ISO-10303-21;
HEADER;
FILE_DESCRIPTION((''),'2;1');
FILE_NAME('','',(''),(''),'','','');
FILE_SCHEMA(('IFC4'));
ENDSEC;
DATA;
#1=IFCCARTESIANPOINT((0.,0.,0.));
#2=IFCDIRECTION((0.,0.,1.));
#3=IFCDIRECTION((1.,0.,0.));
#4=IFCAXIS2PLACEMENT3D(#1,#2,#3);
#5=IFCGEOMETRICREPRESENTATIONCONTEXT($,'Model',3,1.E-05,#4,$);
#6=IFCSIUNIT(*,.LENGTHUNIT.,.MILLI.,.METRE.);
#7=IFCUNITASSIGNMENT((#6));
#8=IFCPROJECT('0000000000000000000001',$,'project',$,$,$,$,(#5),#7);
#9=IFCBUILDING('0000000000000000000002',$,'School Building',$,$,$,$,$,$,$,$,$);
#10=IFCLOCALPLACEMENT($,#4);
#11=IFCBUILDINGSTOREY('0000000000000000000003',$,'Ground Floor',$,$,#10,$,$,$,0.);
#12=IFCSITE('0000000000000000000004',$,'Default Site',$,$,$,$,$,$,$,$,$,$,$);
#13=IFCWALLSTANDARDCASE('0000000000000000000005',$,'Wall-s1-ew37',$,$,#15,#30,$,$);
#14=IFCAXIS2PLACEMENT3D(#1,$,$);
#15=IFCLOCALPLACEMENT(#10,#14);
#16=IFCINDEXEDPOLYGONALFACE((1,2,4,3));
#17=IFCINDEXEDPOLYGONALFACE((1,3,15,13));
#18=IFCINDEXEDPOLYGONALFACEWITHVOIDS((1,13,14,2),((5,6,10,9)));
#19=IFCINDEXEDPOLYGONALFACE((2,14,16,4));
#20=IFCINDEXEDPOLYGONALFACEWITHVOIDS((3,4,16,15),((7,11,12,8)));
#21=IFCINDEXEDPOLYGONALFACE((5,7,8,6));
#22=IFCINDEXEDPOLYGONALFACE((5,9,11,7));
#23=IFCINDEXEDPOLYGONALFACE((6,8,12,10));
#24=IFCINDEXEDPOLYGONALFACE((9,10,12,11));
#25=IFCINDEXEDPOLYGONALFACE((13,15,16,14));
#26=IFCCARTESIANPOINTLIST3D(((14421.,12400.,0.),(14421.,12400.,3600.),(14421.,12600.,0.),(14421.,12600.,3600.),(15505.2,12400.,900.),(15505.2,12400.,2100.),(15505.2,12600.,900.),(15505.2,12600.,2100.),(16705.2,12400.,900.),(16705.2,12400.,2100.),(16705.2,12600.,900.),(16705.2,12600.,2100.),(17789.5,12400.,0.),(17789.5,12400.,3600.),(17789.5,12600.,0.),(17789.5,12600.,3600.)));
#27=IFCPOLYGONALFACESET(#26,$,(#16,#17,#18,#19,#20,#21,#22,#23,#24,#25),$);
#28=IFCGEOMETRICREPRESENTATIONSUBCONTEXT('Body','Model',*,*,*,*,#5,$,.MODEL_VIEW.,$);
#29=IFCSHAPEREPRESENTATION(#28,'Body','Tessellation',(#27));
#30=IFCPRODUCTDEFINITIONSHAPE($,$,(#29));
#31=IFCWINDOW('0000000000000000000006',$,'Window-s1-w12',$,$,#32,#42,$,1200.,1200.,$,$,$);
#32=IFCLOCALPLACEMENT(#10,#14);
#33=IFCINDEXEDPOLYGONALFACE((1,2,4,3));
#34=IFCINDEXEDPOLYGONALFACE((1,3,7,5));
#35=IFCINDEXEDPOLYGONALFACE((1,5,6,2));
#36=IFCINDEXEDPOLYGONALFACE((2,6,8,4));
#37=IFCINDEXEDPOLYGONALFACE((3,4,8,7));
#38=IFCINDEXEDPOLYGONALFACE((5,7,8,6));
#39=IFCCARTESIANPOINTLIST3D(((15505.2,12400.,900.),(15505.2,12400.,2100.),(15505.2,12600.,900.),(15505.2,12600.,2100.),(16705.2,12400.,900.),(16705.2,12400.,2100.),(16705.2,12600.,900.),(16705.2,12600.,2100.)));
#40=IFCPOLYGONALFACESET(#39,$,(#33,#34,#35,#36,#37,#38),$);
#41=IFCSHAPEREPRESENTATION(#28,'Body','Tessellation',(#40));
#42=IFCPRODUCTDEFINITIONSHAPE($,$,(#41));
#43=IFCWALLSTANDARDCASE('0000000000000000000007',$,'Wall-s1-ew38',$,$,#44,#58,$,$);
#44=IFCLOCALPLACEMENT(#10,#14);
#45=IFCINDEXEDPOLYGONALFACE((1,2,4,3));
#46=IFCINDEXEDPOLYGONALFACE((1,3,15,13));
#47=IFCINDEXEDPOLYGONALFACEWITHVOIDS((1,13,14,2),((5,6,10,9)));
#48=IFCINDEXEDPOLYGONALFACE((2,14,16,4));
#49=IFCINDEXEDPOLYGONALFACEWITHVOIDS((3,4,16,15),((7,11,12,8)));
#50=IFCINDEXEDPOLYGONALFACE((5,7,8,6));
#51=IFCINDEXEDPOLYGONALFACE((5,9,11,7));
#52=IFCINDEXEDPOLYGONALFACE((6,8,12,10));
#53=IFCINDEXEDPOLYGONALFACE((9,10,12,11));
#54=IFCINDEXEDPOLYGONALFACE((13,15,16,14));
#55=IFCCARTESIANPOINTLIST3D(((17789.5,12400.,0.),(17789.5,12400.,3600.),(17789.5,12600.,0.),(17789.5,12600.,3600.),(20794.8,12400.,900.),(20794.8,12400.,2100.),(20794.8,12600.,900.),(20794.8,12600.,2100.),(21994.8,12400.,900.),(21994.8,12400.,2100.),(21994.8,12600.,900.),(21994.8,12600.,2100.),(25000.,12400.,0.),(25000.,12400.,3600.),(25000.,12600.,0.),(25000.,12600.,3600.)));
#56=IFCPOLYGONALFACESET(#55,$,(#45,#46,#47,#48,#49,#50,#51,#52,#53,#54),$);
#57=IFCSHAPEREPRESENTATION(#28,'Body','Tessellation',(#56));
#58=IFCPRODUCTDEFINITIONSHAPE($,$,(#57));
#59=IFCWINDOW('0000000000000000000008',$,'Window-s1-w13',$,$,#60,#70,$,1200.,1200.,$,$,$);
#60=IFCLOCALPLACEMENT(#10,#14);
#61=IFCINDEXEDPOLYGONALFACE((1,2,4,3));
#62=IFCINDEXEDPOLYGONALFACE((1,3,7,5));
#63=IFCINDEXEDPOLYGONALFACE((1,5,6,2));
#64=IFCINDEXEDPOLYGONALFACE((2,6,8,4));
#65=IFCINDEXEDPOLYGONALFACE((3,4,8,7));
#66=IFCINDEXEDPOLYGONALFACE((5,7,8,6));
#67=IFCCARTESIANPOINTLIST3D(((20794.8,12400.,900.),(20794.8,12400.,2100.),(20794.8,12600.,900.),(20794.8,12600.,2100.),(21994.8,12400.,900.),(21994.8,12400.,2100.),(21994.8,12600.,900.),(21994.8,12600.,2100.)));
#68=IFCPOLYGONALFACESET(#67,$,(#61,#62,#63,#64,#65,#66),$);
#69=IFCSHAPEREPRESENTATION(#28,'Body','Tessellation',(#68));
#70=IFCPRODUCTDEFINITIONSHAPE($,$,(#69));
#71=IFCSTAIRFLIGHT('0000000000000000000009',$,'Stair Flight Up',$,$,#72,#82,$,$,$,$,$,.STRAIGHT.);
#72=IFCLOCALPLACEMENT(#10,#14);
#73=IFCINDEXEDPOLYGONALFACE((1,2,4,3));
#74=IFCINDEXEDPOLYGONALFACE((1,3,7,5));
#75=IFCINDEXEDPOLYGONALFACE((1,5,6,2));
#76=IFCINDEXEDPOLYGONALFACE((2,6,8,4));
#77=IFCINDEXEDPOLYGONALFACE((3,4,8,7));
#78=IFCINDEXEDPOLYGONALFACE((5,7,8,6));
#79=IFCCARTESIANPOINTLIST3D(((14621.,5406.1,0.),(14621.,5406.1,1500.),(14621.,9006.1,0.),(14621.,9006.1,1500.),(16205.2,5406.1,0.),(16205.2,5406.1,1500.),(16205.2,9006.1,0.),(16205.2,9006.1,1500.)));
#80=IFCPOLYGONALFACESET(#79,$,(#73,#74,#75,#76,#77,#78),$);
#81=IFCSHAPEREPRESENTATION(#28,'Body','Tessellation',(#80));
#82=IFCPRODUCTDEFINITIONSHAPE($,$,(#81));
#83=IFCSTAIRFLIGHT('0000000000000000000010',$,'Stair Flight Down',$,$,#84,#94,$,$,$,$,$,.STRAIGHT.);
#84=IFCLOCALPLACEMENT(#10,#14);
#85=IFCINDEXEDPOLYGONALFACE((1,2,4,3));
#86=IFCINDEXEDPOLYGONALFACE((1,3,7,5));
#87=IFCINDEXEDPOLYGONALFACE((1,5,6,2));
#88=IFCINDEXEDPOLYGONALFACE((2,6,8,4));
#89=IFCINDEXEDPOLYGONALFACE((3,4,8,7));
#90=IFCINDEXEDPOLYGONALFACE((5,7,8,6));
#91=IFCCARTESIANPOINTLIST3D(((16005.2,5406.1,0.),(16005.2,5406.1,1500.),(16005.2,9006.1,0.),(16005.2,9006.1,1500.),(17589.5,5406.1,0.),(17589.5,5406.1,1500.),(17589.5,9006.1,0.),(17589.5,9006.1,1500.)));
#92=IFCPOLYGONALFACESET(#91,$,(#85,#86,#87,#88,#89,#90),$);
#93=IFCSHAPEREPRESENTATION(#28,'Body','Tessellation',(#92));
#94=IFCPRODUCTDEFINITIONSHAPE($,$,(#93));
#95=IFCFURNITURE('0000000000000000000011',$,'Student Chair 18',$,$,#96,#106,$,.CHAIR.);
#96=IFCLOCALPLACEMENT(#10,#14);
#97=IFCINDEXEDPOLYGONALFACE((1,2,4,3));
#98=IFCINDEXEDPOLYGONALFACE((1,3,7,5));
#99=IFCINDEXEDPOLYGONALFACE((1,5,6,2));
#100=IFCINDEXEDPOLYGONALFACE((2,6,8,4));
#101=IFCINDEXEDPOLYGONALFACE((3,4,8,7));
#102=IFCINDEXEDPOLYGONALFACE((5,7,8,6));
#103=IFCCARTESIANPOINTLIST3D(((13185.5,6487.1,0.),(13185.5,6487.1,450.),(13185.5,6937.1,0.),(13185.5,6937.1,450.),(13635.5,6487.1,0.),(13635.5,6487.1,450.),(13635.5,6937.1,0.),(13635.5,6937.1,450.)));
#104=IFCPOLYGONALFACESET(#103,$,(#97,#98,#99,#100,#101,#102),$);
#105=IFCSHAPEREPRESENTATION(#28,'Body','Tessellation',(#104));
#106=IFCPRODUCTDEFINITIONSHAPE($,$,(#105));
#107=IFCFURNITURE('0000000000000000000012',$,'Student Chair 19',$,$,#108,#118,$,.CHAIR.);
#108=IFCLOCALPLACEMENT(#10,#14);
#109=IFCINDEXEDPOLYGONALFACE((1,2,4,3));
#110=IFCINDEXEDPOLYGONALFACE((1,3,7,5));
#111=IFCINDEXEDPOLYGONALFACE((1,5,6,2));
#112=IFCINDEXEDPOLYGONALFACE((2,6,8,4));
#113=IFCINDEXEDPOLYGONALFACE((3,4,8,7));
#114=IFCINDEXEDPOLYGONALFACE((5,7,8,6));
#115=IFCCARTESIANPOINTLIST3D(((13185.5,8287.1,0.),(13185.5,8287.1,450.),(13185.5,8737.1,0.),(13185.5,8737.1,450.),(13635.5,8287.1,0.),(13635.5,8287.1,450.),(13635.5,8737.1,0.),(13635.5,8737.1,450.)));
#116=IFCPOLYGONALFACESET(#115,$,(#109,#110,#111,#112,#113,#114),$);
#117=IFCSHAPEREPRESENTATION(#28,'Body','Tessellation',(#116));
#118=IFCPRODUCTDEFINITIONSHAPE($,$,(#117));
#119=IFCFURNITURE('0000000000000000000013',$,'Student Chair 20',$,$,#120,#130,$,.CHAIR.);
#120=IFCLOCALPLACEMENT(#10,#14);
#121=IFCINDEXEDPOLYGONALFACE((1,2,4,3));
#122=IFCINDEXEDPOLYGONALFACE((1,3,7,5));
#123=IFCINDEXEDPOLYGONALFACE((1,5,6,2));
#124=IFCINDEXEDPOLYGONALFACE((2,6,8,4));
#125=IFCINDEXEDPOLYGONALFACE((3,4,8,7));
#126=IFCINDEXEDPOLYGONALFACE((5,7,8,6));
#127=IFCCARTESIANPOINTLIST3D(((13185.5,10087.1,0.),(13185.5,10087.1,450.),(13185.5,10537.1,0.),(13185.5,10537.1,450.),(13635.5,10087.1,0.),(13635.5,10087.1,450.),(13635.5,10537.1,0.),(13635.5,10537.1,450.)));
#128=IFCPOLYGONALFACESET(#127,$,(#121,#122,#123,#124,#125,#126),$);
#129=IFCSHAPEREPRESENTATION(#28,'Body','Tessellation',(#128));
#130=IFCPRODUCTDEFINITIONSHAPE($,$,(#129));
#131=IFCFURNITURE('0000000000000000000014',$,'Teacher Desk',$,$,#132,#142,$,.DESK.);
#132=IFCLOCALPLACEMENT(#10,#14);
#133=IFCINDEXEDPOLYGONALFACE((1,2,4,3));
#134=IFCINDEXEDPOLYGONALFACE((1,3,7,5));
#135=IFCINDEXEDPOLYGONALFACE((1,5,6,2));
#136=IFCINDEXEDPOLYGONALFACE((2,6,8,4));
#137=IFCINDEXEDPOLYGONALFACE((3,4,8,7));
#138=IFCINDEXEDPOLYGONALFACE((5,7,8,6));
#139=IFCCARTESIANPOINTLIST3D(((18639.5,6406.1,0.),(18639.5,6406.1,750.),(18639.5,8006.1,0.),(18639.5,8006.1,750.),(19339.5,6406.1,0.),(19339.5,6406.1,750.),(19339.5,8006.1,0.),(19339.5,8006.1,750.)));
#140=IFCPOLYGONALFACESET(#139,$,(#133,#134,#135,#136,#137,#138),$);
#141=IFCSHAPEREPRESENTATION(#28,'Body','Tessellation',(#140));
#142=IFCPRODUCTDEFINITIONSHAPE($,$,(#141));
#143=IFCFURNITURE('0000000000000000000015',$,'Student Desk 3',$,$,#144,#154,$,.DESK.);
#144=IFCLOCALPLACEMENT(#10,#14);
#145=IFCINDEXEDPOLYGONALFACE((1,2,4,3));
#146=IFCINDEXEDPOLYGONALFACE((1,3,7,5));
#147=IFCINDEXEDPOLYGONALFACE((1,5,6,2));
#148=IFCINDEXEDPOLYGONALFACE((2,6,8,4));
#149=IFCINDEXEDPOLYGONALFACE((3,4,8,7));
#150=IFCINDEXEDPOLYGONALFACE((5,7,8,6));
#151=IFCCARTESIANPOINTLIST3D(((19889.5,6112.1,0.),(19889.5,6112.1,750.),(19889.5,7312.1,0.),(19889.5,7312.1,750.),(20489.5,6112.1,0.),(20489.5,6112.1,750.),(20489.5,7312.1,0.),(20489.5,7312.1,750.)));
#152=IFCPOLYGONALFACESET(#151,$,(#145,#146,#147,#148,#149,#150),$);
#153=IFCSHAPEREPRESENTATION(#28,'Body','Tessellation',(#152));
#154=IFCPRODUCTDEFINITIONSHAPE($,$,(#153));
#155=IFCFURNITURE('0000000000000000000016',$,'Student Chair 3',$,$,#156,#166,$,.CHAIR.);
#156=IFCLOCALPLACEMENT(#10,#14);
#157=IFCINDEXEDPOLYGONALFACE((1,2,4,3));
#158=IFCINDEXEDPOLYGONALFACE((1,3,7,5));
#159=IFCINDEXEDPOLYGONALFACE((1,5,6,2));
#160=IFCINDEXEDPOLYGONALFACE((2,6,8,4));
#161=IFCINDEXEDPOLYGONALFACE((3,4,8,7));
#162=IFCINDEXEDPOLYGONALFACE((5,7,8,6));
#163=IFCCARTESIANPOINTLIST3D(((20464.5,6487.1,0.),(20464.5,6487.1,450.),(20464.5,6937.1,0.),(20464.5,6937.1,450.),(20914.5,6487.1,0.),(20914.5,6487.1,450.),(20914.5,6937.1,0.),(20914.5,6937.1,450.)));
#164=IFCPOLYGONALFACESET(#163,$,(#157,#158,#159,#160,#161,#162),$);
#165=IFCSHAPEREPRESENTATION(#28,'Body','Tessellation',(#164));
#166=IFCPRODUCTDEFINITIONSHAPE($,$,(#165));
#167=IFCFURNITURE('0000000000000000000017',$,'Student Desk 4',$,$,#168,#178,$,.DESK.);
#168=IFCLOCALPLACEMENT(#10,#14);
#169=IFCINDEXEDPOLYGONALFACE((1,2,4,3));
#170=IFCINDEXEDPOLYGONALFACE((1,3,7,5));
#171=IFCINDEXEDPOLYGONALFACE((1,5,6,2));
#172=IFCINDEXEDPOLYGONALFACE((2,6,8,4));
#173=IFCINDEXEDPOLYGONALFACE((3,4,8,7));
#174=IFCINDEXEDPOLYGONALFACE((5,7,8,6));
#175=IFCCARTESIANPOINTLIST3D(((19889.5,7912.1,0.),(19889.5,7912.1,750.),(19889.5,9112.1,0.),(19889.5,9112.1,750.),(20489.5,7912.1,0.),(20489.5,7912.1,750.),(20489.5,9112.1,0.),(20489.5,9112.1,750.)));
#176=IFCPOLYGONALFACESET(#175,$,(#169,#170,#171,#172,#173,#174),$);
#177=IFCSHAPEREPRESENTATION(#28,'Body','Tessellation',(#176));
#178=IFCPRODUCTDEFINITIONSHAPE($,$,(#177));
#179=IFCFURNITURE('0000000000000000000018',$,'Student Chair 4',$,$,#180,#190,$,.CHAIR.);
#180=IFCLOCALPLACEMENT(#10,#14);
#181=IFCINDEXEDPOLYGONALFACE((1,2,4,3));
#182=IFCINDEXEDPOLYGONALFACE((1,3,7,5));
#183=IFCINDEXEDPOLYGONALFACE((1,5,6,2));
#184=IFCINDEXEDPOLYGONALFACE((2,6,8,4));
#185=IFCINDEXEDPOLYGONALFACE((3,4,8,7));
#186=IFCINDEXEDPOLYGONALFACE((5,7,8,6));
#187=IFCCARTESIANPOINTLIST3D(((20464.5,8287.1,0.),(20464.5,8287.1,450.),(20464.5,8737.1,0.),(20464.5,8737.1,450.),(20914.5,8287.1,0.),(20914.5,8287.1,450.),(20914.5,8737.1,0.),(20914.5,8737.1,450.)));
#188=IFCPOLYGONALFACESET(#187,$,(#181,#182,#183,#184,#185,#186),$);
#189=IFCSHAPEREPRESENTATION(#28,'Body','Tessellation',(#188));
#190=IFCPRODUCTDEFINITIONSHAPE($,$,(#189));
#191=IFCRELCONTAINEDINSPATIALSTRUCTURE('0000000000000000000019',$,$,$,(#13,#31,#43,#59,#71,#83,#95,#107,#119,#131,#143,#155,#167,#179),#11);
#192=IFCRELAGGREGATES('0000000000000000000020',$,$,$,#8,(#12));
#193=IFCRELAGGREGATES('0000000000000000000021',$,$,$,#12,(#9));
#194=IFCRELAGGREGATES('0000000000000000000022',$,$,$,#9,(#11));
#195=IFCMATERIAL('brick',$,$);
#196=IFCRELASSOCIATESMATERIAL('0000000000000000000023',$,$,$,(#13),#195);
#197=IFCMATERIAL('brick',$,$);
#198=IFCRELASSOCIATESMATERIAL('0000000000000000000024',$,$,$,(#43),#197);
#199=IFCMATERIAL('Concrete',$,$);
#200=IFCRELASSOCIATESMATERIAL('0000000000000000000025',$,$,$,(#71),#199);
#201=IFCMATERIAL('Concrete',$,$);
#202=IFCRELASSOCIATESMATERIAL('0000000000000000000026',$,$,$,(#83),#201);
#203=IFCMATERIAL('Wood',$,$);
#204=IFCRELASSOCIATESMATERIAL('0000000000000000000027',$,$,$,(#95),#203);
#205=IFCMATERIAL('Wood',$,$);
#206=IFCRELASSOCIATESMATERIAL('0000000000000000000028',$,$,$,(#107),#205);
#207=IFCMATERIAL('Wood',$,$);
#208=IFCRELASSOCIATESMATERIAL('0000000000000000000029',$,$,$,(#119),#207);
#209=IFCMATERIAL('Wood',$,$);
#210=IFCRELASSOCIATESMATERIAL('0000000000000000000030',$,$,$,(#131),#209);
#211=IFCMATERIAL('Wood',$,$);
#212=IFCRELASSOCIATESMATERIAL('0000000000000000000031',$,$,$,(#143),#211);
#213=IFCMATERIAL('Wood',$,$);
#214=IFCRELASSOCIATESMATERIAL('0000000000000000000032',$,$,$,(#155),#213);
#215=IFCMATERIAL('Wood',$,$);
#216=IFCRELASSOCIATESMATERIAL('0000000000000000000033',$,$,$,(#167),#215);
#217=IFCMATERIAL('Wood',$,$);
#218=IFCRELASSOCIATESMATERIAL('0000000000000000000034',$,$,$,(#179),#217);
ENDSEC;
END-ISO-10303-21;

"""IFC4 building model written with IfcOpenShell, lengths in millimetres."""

from ifc_helpers import new_model, si_unit, frame, frame_2d, origin_with_axes, origin_2d, place, context, subcontext, project, spatial, rectangle, extrude, material, element, fill, save


model = new_model("IFC4")

# Units and contexts
model_context = context("Model", 3, precision=1e-05, world=origin_with_axes())
body_context = subcontext(model_context, "Body", "Model", "MODEL_VIEW")
ifc_project = project(units=[si_unit("LENGTHUNIT", "METRE", prefix="MILLI")], contexts=[model_context])

# Site, building, storey
site = spatial("IfcSite", under=ifc_project, Name="Default Site")
building = spatial("IfcBuilding", under=site, Name="School Building")
storey_placement = place(None, origin_with_axes())
storey = spatial("IfcBuildingStorey", under=building, at=storey_placement, Name="Ground Floor", Elevation=0.0)

# Walls, openings, windows
ifc_material_1 = material(Name="brick")
wall_1_placement = place(storey_placement, frame((14421.0, 12500.0, 0.0), z_axis=(0.0, 0.0, 1.0), x_axis=(1.0, 0.0, 0.0)))
wall_1 = element("IfcWallStandardCase", 1, at=wall_1_placement, inside=storey, material=ifc_material_1, Name="Wall-s1-ew37", context=body_context, shape_type="SweptSolid", body=[
    extrude(rectangle(XDim=3368.6, YDim=200.0, at=frame_2d((1684.3, 0.0))), origin_with_axes(), (0.0, 0.0, 1.0), 3600.0),
])
opening_1_placement = place(wall_1_placement, frame((1084.3, 0.0, 900.0), z_axis=(0.0, 0.0, 1.0), x_axis=(1.0, 0.0, 0.0)))
opening_1 = element("IfcOpeningElement", 2, at=opening_1_placement, cuts=wall_1, context=body_context, shape_type="SweptSolid", body=[
    extrude(rectangle(XDim=1200.0, YDim=400.0, at=frame_2d((600.0, 0.0))), origin_with_axes(), (0.0, 0.0, 1.0), 1200.0),
])
window_1_placement = place(storey_placement, frame((15505.2, 12500.0, 900.0), z_axis=(0.0, 0.0, 1.0), x_axis=(1.0, 0.0, 0.0)))
window_1 = element("IfcWindow", 3, at=window_1_placement, inside=storey, Name="Window-s1-w12", OverallHeight=1200.0, OverallWidth=1200.0, context=body_context, shape_type="SweptSolid", body=[
    extrude(rectangle(XDim=1200.0, YDim=200.0, at=frame_2d((600.0, 0.0))), origin_with_axes(), (0.0, 0.0, 1.0), 1200.0),
])
fill(opening_1, window_1)
ifc_material_2 = material(Name="brick")
wall_2_placement = place(storey_placement, frame((17789.5, 12500.0, 0.0), z_axis=(0.0, 0.0, 1.0), x_axis=(1.0, 0.0, 0.0)))
wall_2 = element("IfcWallStandardCase", 4, at=wall_2_placement, inside=storey, material=ifc_material_2, Name="Wall-s1-ew38", context=body_context, shape_type="SweptSolid", body=[
    extrude(rectangle(XDim=7210.5, YDim=200.0, at=frame_2d((3605.2, 0.0))), origin_with_axes(), (0.0, 0.0, 1.0), 3600.0),
])
opening_2_placement = place(wall_2_placement, frame((3005.2, 0.0, 900.0), z_axis=(0.0, 0.0, 1.0), x_axis=(1.0, 0.0, 0.0)))
opening_2 = element("IfcOpeningElement", 5, at=opening_2_placement, cuts=wall_2, context=body_context, shape_type="SweptSolid", body=[
    extrude(rectangle(XDim=1200.0, YDim=400.0, at=frame_2d((600.0, 0.0))), origin_with_axes(), (0.0, 0.0, 1.0), 1200.0),
])
window_2_placement = place(storey_placement, frame((20794.8, 12500.0, 900.0), z_axis=(0.0, 0.0, 1.0), x_axis=(1.0, 0.0, 0.0)))
window_2 = element("IfcWindow", 6, at=window_2_placement, inside=storey, Name="Window-s1-w13", OverallHeight=1200.0, OverallWidth=1200.0, context=body_context, shape_type="SweptSolid", body=[
    extrude(rectangle(XDim=1200.0, YDim=200.0, at=frame_2d((600.0, 0.0))), origin_with_axes(), (0.0, 0.0, 1.0), 1200.0),
])
fill(opening_2, window_2)

# Stair flights
ifc_material_3 = material(Name="Concrete")
stair_flight_1_placement = place(storey_placement, frame((15413.1, 7206.1, 0.0), z_axis=(0.0, 0.0, 1.0), x_axis=(1.0, 0.0, 0.0)))
element("IfcStairFlight", 7, at=stair_flight_1_placement, inside=storey, material=ifc_material_3, Name="Stair Flight Up", PredefinedType="STRAIGHT", context=body_context, shape_type="SweptSolid", body=[
    extrude(rectangle(XDim=1584.3, YDim=3600.0, at=origin_2d()), origin_with_axes(), (0.0, 0.0, 1.0), 1500.0),
])
ifc_material_4 = material(Name="Concrete")
stair_flight_2_placement = place(storey_placement, frame((16797.4, 7206.1, 0.0), z_axis=(0.0, 0.0, 1.0), x_axis=(1.0, 0.0, 0.0)))
element("IfcStairFlight", 8, at=stair_flight_2_placement, inside=storey, material=ifc_material_4, Name="Stair Flight Down", PredefinedType="STRAIGHT", context=body_context, shape_type="SweptSolid", body=[
    extrude(rectangle(XDim=1584.3, YDim=3600.0, at=origin_2d()), origin_with_axes(), (0.0, 0.0, 1.0), 1500.0),
])

# Furniture
ifc_material_5 = material(Name="Wood")
furniture_1_placement = place(storey_placement, frame((13410.5, 6712.1, 0.0), z_axis=(0.0, 0.0, 1.0), x_axis=(1.0, 0.0, 0.0)))
element("IfcFurniture", 9, at=furniture_1_placement, inside=storey, material=ifc_material_5, Name="Student Chair 18", PredefinedType="CHAIR", context=body_context, shape_type="SweptSolid", body=[
    extrude(rectangle(XDim=450.0, YDim=450.0, at=origin_2d()), origin_with_axes(), (0.0, 0.0, 1.0), 450.0),
])
ifc_material_6 = material(Name="Wood")
furniture_2_placement = place(storey_placement, frame((13410.5, 8512.1, 0.0), z_axis=(0.0, 0.0, 1.0), x_axis=(1.0, 0.0, 0.0)))
element("IfcFurniture", 10, at=furniture_2_placement, inside=storey, material=ifc_material_6, Name="Student Chair 19", PredefinedType="CHAIR", context=body_context, shape_type="SweptSolid", body=[
    extrude(rectangle(XDim=450.0, YDim=450.0, at=origin_2d()), origin_with_axes(), (0.0, 0.0, 1.0), 450.0),
])
ifc_material_7 = material(Name="Wood")
furniture_3_placement = place(storey_placement, frame((13410.5, 10312.1, 0.0), z_axis=(0.0, 0.0, 1.0), x_axis=(1.0, 0.0, 0.0)))
element("IfcFurniture", 11, at=furniture_3_placement, inside=storey, material=ifc_material_7, Name="Student Chair 20", PredefinedType="CHAIR", context=body_context, shape_type="SweptSolid", body=[
    extrude(rectangle(XDim=450.0, YDim=450.0, at=origin_2d()), origin_with_axes(), (0.0, 0.0, 1.0), 450.0),
])
ifc_material_8 = material(Name="Wood")
furniture_4_placement = place(storey_placement, frame((18989.5, 7206.1, 0.0), z_axis=(0.0, 0.0, 1.0), x_axis=(0.0, 1.0, 0.0)))
element("IfcFurniture", 12, at=furniture_4_placement, inside=storey, material=ifc_material_8, Name="Teacher Desk", PredefinedType="DESK", context=body_context, shape_type="SweptSolid", body=[
    extrude(rectangle(XDim=1600.0, YDim=700.0, at=origin_2d()), origin_with_axes(), (0.0, 0.0, 1.0), 750.0),
])
ifc_material_9 = material(Name="Wood")
furniture_5_placement = place(storey_placement, frame((20189.5, 6712.1, 0.0), z_axis=(0.0, 0.0, 1.0), x_axis=(0.0, 1.0, 0.0)))
element("IfcFurniture", 13, at=furniture_5_placement, inside=storey, material=ifc_material_9, Name="Student Desk 3", PredefinedType="DESK", context=body_context, shape_type="SweptSolid", body=[
    extrude(rectangle(XDim=1200.0, YDim=600.0, at=origin_2d()), origin_with_axes(), (0.0, 0.0, 1.0), 750.0),
])
ifc_material_10 = material(Name="Wood")
furniture_6_placement = place(storey_placement, frame((20689.5, 6712.1, 0.0), z_axis=(0.0, 0.0, 1.0), x_axis=(1.0, 0.0, 0.0)))
element("IfcFurniture", 14, at=furniture_6_placement, inside=storey, material=ifc_material_10, Name="Student Chair 3", PredefinedType="CHAIR", context=body_context, shape_type="SweptSolid", body=[
    extrude(rectangle(XDim=450.0, YDim=450.0, at=origin_2d()), origin_with_axes(), (0.0, 0.0, 1.0), 450.0),
])
ifc_material_11 = material(Name="Wood")
furniture_7_placement = place(storey_placement, frame((20189.5, 8512.1, 0.0), z_axis=(0.0, 0.0, 1.0), x_axis=(0.0, 1.0, 0.0)))
element("IfcFurniture", 15, at=furniture_7_placement, inside=storey, material=ifc_material_11, Name="Student Desk 4", PredefinedType="DESK", context=body_context, shape_type="SweptSolid", body=[
    extrude(rectangle(XDim=1200.0, YDim=600.0, at=origin_2d()), origin_with_axes(), (0.0, 0.0, 1.0), 750.0),
])
ifc_material_12 = material(Name="Wood")
furniture_8_placement = place(storey_placement, frame((20689.5, 8512.1, 0.0), z_axis=(0.0, 0.0, 1.0), x_axis=(1.0, 0.0, 0.0)))
element("IfcFurniture", 16, at=furniture_8_placement, inside=storey, material=ifc_material_12, Name="Student Chair 4", PredefinedType="CHAIR", context=body_context, shape_type="SweptSolid", body=[
    extrude(rectangle(XDim=450.0, YDim=450.0, at=origin_2d()), origin_with_axes(), (0.0, 0.0, 1.0), 450.0),
])

save(model, "model.ifc")
